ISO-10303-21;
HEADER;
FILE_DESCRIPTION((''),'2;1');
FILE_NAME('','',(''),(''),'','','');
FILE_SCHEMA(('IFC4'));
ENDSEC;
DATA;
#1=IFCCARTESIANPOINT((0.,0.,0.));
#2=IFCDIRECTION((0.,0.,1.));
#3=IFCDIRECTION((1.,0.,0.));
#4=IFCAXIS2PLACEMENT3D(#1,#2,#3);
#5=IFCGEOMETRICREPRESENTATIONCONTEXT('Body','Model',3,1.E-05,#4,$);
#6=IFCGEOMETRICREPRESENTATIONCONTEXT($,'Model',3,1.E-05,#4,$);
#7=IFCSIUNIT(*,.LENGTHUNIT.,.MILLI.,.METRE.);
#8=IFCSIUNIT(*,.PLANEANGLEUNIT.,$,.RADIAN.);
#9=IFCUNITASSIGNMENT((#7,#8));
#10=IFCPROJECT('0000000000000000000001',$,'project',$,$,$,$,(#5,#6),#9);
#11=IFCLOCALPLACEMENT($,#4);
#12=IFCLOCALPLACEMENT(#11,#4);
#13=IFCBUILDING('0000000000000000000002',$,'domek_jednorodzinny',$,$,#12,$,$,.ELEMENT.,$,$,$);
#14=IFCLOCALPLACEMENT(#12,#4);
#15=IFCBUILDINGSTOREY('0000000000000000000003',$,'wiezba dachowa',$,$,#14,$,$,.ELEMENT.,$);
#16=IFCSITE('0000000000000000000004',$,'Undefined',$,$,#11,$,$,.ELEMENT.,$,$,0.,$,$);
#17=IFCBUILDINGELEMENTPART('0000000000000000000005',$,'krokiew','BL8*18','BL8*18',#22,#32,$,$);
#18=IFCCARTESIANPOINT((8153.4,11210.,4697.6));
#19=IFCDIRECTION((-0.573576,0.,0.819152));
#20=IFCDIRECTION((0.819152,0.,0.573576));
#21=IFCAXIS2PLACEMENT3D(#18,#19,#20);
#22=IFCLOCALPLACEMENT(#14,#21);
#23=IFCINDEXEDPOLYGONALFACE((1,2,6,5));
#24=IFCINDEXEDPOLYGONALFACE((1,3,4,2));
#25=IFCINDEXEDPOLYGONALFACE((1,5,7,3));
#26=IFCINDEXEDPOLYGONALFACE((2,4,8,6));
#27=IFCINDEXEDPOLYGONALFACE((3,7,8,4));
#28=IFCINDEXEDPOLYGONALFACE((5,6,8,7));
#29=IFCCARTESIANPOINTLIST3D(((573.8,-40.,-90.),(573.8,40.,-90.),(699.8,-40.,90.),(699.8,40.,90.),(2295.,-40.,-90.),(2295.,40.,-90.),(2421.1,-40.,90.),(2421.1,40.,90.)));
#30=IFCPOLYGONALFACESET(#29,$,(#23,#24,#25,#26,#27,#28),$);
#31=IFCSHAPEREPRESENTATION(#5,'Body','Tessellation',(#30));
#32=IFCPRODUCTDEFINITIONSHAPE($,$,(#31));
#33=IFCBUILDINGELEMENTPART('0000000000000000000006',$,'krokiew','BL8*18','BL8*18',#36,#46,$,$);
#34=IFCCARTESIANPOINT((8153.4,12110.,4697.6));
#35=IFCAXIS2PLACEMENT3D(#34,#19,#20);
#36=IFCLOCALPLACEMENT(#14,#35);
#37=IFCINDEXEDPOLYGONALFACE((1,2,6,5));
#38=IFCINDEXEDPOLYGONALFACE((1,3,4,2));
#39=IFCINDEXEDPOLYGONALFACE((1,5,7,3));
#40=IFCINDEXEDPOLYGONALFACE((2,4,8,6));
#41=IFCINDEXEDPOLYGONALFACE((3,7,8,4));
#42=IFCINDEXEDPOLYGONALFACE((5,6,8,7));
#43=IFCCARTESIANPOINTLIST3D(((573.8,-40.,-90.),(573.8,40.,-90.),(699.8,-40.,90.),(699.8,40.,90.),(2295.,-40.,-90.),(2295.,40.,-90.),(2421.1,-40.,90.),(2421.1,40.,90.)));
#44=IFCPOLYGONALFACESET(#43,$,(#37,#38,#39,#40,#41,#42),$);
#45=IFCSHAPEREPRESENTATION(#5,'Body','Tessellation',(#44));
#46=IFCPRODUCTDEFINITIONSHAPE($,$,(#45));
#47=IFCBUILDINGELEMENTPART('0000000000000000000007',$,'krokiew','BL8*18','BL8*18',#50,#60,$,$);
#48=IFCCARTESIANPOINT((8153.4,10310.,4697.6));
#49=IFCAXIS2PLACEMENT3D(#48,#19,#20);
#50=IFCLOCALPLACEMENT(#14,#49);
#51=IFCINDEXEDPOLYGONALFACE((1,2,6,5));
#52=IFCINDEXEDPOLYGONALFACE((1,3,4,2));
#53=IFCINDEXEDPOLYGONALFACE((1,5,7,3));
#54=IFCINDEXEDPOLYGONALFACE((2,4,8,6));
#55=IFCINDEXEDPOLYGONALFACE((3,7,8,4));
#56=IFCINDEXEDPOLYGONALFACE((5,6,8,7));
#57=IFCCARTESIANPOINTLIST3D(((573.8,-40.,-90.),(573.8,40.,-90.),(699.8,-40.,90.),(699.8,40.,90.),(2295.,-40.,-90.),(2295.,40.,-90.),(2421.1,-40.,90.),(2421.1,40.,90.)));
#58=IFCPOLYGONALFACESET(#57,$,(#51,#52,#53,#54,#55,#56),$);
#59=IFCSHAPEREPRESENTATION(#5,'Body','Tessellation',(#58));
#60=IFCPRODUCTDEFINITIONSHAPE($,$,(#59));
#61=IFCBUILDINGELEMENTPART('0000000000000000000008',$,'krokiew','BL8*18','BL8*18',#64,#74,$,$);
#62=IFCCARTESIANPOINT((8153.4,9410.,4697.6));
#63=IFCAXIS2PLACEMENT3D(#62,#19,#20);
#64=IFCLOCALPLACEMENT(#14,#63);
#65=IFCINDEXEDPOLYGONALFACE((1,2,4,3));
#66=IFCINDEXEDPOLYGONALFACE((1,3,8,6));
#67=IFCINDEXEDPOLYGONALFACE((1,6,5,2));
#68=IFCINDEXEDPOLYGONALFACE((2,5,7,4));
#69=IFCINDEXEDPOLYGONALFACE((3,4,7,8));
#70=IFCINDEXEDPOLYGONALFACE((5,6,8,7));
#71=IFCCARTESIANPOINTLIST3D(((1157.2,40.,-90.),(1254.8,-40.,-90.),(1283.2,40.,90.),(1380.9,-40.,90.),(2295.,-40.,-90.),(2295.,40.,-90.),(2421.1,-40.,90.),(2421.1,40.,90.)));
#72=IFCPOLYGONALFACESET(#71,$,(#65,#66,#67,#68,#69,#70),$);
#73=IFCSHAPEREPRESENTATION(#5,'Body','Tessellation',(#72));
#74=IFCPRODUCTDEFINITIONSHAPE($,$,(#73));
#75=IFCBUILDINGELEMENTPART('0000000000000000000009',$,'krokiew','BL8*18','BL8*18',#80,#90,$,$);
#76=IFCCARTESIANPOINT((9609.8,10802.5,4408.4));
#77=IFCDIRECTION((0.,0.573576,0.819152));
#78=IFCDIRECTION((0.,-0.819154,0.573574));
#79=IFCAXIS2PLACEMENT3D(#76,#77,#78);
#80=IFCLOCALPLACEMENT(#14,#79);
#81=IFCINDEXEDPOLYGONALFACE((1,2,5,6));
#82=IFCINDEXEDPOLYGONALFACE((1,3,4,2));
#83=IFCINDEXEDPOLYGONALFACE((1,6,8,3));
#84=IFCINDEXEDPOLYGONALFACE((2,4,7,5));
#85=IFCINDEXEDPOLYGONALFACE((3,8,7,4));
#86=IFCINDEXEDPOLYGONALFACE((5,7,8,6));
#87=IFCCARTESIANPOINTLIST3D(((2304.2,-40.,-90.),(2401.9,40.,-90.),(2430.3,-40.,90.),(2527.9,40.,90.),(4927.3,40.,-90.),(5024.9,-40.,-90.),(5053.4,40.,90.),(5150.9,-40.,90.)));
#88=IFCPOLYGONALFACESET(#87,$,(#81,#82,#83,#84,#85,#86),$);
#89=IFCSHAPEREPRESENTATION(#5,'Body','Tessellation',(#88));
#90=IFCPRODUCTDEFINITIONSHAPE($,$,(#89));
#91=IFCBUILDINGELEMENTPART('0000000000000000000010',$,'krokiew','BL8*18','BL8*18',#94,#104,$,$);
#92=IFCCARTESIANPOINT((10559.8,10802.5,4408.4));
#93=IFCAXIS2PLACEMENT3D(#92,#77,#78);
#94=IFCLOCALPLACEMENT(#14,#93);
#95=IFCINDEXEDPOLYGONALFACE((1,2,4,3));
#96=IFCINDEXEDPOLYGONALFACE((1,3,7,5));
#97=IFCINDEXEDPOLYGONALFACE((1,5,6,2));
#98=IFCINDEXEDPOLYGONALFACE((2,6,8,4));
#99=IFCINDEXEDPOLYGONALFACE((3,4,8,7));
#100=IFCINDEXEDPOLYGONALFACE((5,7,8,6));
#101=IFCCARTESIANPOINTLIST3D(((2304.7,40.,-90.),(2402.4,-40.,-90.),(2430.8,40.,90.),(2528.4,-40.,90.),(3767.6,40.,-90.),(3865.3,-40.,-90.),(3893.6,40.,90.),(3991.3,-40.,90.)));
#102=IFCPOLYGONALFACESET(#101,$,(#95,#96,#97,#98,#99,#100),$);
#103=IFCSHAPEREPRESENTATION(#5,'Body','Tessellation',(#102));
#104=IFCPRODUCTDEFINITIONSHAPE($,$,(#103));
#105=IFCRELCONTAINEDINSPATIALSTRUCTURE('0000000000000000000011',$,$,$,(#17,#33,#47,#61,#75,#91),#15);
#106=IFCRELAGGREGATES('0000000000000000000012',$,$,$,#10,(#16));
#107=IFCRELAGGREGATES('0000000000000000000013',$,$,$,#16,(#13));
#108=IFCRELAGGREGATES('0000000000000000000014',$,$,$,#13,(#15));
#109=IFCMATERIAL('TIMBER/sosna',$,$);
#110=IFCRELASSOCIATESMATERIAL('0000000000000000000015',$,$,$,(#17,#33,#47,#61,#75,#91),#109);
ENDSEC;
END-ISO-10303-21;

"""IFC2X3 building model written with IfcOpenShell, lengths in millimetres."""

from ifc_helpers import new_model, si_unit, frame, origin_with_axes, origin_2d_with_axis, place, context, project, spatial, rectangle, extrude, clip, halfspace, material, element, save


model = new_model("IFC2X3")

# Units and contexts
model_context_1 = context("Model", 3, precision=1e-05, world=origin_with_axes(), identifier="Body")
model_context_2 = context("Model", 3, precision=1e-05, world=origin_with_axes())
ifc_project = project(units=[si_unit("LENGTHUNIT", "METRE", prefix="MILLI"), si_unit("PLANEANGLEUNIT", "RADIAN")], contexts=[model_context_1, model_context_2])

# Site, building, storey
site_placement = place(None, origin_with_axes())
site = spatial("IfcSite", under=ifc_project, at=site_placement, Name="Undefined", CompositionType="ELEMENT", RefElevation=0.0)
building_placement = place(site_placement, origin_with_axes())
building = spatial("IfcBuilding", under=site, at=building_placement, Name="domek_jednorodzinny", CompositionType="ELEMENT")
storey_placement = place(building_placement, origin_with_axes())
storey = spatial("IfcBuildingStorey", under=building, at=storey_placement, Name="wiezba dachowa", CompositionType="ELEMENT")

# Building element parts
ifc_material = material(Name="TIMBER/sosna")
building_element_part_1_placement = place(storey_placement, frame((8153.4, 11210.0, 4697.6), z_axis=(-0.573576, 0.0, 0.819152), x_axis=(0.819152, 0.0, 0.573576)))
element("IfcBuildingElementPart", 1, at=building_element_part_1_placement, inside=storey, material=ifc_material, Name="krokiew", Description="BL8*18", ObjectType="BL8*18", context=model_context_1, shape_type="Clipping", body=[
    clip(clip(extrude(rectangle(XDim=80.0, YDim=180.0, at=origin_2d_with_axis()), frame((2421.1, 0.0, 0.0), z_axis=(-1.0, 0.0, 0.0), x_axis=(0.0, -1.0, 0.0)), (0.0, 0.0, 1.0), 2421.1), halfspace(frame((2295.0, 40.0, -90.0), z_axis=(0.819151, 0.0, -0.573578), x_axis=(0.0, -1.0, 0.0)), False)), halfspace(frame((385.0, -40.0, -359.6), z_axis=(-0.819152, 0.0, 0.573576), x_axis=(0.0, 1.0, 0.0)), False)),
])
building_element_part_2_placement = place(storey_placement, frame((8153.4, 12110.0, 4697.6), z_axis=(-0.573576, 0.0, 0.819152), x_axis=(0.819152, 0.0, 0.573576)))
element("IfcBuildingElementPart", 2, at=building_element_part_2_placement, inside=storey, material=ifc_material, Name="krokiew", Description="BL8*18", ObjectType="BL8*18", context=model_context_1, shape_type="Clipping", body=[
    clip(clip(extrude(rectangle(XDim=80.0, YDim=180.0, at=origin_2d_with_axis()), frame((2421.1, 0.0, 0.0), z_axis=(-1.0, 0.0, 0.0), x_axis=(0.0, -1.0, 0.0)), (0.0, 0.0, 1.0), 2421.1), halfspace(frame((2295.0, 40.0, -90.0), z_axis=(0.819151, 0.0, -0.573578), x_axis=(0.0, -1.0, 0.0)), False)), halfspace(frame((385.0, -40.0, -359.6), z_axis=(-0.819152, 0.0, 0.573576), x_axis=(0.0, 1.0, 0.0)), False)),
])
building_element_part_3_placement = place(storey_placement, frame((8153.4, 10310.0, 4697.6), z_axis=(-0.573576, 0.0, 0.819152), x_axis=(0.819152, 0.0, 0.573576)))
element("IfcBuildingElementPart", 3, at=building_element_part_3_placement, inside=storey, material=ifc_material, Name="krokiew", Description="BL8*18", ObjectType="BL8*18", context=model_context_1, shape_type="Clipping", body=[
    clip(clip(extrude(rectangle(XDim=80.0, YDim=180.0, at=origin_2d_with_axis()), frame((2421.1, 0.0, 0.0), z_axis=(-1.0, 0.0, 0.0), x_axis=(0.0, -1.0, 0.0)), (0.0, 0.0, 1.0), 2421.1), halfspace(frame((2295.0, 40.0, -90.0), z_axis=(0.819151, 0.0, -0.573578), x_axis=(0.0, -1.0, 0.0)), False)), halfspace(frame((385.0, -40.0, -359.6), z_axis=(-0.819152, 0.0, 0.573576), x_axis=(0.0, 1.0, 0.0)), False)),
])
building_element_part_4_placement = place(storey_placement, frame((8153.4, 9410.0, 4697.6), z_axis=(-0.573576, 0.0, 0.819152), x_axis=(0.819152, 0.0, 0.573576)))
element("IfcBuildingElementPart", 4, at=building_element_part_4_placement, inside=storey, material=ifc_material, Name="krokiew", Description="BL8*18", ObjectType="BL8*18", context=model_context_1, shape_type="Clipping", body=[
    clip(clip(clip(extrude(rectangle(XDim=80.0, YDim=180.0, at=origin_2d_with_axis()), frame((2421.1, 0.0, 0.0), z_axis=(-1.0, 0.0, 0.0), x_axis=(0.0, -1.0, 0.0)), (0.0, 0.0, 1.0), 2421.1), halfspace(frame((2295.0, 40.0, -90.0), z_axis=(0.819151, 0.0, -0.573578), x_axis=(0.0, -1.0, 0.0)), False)), halfspace(frame((16.4, -40.0, -101.5), z_axis=(-0.819152, 0.0, 0.573576), x_axis=(0.0, 1.0, 0.0)), False)), halfspace(frame((1254.8, -40.0, -90.0), z_axis=(-0.579227, -0.707107, 0.405581), x_axis=(-0.77359, 0.633686, 0.0)), False)),
])
building_element_part_5_placement = place(storey_placement, frame((9609.8, 10802.5, 4408.4), z_axis=(0.0, 0.573576, 0.819152), x_axis=(0.0, -0.819154, 0.573574)))
element("IfcBuildingElementPart", 5, at=building_element_part_5_placement, inside=storey, material=ifc_material, Name="krokiew", Description="BL8*18", ObjectType="BL8*18", context=model_context_1, shape_type="Clipping", body=[
    clip(clip(extrude(rectangle(XDim=80.0, YDim=180.0, at=origin_2d_with_axis()), frame((5727.3, 0.0, 0.0), z_axis=(-1.0, 0.0, 0.0), x_axis=(0.0, -1.0, 0.0)), (0.0, 0.0, 1.0), 5727.3), halfspace(frame((2401.9, 40.0, -90.0), z_axis=(-0.57923, 0.707106, 0.405578), x_axis=(0.573578, 0.0, 0.819151)), False)), halfspace(frame((5024.9, -40.0, -90.0), z_axis=(0.579502, 0.706773, -0.405769), x_axis=(0.573578, 0.0, 0.819151)), False)),
])
building_element_part_6_placement = place(storey_placement, frame((10559.8, 10802.5, 4408.4), z_axis=(0.0, 0.573576, 0.819152), x_axis=(0.0, -0.819154, 0.573574)))
element("IfcBuildingElementPart", 6, at=building_element_part_6_placement, inside=storey, material=ifc_material, Name="krokiew", Description="BL8*18", ObjectType="BL8*18", context=model_context_1, shape_type="Clipping", body=[
    clip(clip(extrude(rectangle(XDim=80.0, YDim=180.0, at=origin_2d_with_axis()), frame((5727.3, 0.0, 0.0), z_axis=(-1.0, 0.0, 0.0), x_axis=(0.0, -1.0, 0.0)), (0.0, 0.0, 1.0), 5727.3), halfspace(frame((2304.7, 40.0, -90.0), z_axis=(-0.579227, -0.707107, 0.405581), x_axis=(0.573578, 0.0, 0.819151)), False)), halfspace(frame((3865.3, -40.0, -90.0), z_axis=(0.579226, 0.707109, -0.405579), x_axis=(0.573578, 0.0, 0.819151)), False)),
])

save(model, "model.ifc")
